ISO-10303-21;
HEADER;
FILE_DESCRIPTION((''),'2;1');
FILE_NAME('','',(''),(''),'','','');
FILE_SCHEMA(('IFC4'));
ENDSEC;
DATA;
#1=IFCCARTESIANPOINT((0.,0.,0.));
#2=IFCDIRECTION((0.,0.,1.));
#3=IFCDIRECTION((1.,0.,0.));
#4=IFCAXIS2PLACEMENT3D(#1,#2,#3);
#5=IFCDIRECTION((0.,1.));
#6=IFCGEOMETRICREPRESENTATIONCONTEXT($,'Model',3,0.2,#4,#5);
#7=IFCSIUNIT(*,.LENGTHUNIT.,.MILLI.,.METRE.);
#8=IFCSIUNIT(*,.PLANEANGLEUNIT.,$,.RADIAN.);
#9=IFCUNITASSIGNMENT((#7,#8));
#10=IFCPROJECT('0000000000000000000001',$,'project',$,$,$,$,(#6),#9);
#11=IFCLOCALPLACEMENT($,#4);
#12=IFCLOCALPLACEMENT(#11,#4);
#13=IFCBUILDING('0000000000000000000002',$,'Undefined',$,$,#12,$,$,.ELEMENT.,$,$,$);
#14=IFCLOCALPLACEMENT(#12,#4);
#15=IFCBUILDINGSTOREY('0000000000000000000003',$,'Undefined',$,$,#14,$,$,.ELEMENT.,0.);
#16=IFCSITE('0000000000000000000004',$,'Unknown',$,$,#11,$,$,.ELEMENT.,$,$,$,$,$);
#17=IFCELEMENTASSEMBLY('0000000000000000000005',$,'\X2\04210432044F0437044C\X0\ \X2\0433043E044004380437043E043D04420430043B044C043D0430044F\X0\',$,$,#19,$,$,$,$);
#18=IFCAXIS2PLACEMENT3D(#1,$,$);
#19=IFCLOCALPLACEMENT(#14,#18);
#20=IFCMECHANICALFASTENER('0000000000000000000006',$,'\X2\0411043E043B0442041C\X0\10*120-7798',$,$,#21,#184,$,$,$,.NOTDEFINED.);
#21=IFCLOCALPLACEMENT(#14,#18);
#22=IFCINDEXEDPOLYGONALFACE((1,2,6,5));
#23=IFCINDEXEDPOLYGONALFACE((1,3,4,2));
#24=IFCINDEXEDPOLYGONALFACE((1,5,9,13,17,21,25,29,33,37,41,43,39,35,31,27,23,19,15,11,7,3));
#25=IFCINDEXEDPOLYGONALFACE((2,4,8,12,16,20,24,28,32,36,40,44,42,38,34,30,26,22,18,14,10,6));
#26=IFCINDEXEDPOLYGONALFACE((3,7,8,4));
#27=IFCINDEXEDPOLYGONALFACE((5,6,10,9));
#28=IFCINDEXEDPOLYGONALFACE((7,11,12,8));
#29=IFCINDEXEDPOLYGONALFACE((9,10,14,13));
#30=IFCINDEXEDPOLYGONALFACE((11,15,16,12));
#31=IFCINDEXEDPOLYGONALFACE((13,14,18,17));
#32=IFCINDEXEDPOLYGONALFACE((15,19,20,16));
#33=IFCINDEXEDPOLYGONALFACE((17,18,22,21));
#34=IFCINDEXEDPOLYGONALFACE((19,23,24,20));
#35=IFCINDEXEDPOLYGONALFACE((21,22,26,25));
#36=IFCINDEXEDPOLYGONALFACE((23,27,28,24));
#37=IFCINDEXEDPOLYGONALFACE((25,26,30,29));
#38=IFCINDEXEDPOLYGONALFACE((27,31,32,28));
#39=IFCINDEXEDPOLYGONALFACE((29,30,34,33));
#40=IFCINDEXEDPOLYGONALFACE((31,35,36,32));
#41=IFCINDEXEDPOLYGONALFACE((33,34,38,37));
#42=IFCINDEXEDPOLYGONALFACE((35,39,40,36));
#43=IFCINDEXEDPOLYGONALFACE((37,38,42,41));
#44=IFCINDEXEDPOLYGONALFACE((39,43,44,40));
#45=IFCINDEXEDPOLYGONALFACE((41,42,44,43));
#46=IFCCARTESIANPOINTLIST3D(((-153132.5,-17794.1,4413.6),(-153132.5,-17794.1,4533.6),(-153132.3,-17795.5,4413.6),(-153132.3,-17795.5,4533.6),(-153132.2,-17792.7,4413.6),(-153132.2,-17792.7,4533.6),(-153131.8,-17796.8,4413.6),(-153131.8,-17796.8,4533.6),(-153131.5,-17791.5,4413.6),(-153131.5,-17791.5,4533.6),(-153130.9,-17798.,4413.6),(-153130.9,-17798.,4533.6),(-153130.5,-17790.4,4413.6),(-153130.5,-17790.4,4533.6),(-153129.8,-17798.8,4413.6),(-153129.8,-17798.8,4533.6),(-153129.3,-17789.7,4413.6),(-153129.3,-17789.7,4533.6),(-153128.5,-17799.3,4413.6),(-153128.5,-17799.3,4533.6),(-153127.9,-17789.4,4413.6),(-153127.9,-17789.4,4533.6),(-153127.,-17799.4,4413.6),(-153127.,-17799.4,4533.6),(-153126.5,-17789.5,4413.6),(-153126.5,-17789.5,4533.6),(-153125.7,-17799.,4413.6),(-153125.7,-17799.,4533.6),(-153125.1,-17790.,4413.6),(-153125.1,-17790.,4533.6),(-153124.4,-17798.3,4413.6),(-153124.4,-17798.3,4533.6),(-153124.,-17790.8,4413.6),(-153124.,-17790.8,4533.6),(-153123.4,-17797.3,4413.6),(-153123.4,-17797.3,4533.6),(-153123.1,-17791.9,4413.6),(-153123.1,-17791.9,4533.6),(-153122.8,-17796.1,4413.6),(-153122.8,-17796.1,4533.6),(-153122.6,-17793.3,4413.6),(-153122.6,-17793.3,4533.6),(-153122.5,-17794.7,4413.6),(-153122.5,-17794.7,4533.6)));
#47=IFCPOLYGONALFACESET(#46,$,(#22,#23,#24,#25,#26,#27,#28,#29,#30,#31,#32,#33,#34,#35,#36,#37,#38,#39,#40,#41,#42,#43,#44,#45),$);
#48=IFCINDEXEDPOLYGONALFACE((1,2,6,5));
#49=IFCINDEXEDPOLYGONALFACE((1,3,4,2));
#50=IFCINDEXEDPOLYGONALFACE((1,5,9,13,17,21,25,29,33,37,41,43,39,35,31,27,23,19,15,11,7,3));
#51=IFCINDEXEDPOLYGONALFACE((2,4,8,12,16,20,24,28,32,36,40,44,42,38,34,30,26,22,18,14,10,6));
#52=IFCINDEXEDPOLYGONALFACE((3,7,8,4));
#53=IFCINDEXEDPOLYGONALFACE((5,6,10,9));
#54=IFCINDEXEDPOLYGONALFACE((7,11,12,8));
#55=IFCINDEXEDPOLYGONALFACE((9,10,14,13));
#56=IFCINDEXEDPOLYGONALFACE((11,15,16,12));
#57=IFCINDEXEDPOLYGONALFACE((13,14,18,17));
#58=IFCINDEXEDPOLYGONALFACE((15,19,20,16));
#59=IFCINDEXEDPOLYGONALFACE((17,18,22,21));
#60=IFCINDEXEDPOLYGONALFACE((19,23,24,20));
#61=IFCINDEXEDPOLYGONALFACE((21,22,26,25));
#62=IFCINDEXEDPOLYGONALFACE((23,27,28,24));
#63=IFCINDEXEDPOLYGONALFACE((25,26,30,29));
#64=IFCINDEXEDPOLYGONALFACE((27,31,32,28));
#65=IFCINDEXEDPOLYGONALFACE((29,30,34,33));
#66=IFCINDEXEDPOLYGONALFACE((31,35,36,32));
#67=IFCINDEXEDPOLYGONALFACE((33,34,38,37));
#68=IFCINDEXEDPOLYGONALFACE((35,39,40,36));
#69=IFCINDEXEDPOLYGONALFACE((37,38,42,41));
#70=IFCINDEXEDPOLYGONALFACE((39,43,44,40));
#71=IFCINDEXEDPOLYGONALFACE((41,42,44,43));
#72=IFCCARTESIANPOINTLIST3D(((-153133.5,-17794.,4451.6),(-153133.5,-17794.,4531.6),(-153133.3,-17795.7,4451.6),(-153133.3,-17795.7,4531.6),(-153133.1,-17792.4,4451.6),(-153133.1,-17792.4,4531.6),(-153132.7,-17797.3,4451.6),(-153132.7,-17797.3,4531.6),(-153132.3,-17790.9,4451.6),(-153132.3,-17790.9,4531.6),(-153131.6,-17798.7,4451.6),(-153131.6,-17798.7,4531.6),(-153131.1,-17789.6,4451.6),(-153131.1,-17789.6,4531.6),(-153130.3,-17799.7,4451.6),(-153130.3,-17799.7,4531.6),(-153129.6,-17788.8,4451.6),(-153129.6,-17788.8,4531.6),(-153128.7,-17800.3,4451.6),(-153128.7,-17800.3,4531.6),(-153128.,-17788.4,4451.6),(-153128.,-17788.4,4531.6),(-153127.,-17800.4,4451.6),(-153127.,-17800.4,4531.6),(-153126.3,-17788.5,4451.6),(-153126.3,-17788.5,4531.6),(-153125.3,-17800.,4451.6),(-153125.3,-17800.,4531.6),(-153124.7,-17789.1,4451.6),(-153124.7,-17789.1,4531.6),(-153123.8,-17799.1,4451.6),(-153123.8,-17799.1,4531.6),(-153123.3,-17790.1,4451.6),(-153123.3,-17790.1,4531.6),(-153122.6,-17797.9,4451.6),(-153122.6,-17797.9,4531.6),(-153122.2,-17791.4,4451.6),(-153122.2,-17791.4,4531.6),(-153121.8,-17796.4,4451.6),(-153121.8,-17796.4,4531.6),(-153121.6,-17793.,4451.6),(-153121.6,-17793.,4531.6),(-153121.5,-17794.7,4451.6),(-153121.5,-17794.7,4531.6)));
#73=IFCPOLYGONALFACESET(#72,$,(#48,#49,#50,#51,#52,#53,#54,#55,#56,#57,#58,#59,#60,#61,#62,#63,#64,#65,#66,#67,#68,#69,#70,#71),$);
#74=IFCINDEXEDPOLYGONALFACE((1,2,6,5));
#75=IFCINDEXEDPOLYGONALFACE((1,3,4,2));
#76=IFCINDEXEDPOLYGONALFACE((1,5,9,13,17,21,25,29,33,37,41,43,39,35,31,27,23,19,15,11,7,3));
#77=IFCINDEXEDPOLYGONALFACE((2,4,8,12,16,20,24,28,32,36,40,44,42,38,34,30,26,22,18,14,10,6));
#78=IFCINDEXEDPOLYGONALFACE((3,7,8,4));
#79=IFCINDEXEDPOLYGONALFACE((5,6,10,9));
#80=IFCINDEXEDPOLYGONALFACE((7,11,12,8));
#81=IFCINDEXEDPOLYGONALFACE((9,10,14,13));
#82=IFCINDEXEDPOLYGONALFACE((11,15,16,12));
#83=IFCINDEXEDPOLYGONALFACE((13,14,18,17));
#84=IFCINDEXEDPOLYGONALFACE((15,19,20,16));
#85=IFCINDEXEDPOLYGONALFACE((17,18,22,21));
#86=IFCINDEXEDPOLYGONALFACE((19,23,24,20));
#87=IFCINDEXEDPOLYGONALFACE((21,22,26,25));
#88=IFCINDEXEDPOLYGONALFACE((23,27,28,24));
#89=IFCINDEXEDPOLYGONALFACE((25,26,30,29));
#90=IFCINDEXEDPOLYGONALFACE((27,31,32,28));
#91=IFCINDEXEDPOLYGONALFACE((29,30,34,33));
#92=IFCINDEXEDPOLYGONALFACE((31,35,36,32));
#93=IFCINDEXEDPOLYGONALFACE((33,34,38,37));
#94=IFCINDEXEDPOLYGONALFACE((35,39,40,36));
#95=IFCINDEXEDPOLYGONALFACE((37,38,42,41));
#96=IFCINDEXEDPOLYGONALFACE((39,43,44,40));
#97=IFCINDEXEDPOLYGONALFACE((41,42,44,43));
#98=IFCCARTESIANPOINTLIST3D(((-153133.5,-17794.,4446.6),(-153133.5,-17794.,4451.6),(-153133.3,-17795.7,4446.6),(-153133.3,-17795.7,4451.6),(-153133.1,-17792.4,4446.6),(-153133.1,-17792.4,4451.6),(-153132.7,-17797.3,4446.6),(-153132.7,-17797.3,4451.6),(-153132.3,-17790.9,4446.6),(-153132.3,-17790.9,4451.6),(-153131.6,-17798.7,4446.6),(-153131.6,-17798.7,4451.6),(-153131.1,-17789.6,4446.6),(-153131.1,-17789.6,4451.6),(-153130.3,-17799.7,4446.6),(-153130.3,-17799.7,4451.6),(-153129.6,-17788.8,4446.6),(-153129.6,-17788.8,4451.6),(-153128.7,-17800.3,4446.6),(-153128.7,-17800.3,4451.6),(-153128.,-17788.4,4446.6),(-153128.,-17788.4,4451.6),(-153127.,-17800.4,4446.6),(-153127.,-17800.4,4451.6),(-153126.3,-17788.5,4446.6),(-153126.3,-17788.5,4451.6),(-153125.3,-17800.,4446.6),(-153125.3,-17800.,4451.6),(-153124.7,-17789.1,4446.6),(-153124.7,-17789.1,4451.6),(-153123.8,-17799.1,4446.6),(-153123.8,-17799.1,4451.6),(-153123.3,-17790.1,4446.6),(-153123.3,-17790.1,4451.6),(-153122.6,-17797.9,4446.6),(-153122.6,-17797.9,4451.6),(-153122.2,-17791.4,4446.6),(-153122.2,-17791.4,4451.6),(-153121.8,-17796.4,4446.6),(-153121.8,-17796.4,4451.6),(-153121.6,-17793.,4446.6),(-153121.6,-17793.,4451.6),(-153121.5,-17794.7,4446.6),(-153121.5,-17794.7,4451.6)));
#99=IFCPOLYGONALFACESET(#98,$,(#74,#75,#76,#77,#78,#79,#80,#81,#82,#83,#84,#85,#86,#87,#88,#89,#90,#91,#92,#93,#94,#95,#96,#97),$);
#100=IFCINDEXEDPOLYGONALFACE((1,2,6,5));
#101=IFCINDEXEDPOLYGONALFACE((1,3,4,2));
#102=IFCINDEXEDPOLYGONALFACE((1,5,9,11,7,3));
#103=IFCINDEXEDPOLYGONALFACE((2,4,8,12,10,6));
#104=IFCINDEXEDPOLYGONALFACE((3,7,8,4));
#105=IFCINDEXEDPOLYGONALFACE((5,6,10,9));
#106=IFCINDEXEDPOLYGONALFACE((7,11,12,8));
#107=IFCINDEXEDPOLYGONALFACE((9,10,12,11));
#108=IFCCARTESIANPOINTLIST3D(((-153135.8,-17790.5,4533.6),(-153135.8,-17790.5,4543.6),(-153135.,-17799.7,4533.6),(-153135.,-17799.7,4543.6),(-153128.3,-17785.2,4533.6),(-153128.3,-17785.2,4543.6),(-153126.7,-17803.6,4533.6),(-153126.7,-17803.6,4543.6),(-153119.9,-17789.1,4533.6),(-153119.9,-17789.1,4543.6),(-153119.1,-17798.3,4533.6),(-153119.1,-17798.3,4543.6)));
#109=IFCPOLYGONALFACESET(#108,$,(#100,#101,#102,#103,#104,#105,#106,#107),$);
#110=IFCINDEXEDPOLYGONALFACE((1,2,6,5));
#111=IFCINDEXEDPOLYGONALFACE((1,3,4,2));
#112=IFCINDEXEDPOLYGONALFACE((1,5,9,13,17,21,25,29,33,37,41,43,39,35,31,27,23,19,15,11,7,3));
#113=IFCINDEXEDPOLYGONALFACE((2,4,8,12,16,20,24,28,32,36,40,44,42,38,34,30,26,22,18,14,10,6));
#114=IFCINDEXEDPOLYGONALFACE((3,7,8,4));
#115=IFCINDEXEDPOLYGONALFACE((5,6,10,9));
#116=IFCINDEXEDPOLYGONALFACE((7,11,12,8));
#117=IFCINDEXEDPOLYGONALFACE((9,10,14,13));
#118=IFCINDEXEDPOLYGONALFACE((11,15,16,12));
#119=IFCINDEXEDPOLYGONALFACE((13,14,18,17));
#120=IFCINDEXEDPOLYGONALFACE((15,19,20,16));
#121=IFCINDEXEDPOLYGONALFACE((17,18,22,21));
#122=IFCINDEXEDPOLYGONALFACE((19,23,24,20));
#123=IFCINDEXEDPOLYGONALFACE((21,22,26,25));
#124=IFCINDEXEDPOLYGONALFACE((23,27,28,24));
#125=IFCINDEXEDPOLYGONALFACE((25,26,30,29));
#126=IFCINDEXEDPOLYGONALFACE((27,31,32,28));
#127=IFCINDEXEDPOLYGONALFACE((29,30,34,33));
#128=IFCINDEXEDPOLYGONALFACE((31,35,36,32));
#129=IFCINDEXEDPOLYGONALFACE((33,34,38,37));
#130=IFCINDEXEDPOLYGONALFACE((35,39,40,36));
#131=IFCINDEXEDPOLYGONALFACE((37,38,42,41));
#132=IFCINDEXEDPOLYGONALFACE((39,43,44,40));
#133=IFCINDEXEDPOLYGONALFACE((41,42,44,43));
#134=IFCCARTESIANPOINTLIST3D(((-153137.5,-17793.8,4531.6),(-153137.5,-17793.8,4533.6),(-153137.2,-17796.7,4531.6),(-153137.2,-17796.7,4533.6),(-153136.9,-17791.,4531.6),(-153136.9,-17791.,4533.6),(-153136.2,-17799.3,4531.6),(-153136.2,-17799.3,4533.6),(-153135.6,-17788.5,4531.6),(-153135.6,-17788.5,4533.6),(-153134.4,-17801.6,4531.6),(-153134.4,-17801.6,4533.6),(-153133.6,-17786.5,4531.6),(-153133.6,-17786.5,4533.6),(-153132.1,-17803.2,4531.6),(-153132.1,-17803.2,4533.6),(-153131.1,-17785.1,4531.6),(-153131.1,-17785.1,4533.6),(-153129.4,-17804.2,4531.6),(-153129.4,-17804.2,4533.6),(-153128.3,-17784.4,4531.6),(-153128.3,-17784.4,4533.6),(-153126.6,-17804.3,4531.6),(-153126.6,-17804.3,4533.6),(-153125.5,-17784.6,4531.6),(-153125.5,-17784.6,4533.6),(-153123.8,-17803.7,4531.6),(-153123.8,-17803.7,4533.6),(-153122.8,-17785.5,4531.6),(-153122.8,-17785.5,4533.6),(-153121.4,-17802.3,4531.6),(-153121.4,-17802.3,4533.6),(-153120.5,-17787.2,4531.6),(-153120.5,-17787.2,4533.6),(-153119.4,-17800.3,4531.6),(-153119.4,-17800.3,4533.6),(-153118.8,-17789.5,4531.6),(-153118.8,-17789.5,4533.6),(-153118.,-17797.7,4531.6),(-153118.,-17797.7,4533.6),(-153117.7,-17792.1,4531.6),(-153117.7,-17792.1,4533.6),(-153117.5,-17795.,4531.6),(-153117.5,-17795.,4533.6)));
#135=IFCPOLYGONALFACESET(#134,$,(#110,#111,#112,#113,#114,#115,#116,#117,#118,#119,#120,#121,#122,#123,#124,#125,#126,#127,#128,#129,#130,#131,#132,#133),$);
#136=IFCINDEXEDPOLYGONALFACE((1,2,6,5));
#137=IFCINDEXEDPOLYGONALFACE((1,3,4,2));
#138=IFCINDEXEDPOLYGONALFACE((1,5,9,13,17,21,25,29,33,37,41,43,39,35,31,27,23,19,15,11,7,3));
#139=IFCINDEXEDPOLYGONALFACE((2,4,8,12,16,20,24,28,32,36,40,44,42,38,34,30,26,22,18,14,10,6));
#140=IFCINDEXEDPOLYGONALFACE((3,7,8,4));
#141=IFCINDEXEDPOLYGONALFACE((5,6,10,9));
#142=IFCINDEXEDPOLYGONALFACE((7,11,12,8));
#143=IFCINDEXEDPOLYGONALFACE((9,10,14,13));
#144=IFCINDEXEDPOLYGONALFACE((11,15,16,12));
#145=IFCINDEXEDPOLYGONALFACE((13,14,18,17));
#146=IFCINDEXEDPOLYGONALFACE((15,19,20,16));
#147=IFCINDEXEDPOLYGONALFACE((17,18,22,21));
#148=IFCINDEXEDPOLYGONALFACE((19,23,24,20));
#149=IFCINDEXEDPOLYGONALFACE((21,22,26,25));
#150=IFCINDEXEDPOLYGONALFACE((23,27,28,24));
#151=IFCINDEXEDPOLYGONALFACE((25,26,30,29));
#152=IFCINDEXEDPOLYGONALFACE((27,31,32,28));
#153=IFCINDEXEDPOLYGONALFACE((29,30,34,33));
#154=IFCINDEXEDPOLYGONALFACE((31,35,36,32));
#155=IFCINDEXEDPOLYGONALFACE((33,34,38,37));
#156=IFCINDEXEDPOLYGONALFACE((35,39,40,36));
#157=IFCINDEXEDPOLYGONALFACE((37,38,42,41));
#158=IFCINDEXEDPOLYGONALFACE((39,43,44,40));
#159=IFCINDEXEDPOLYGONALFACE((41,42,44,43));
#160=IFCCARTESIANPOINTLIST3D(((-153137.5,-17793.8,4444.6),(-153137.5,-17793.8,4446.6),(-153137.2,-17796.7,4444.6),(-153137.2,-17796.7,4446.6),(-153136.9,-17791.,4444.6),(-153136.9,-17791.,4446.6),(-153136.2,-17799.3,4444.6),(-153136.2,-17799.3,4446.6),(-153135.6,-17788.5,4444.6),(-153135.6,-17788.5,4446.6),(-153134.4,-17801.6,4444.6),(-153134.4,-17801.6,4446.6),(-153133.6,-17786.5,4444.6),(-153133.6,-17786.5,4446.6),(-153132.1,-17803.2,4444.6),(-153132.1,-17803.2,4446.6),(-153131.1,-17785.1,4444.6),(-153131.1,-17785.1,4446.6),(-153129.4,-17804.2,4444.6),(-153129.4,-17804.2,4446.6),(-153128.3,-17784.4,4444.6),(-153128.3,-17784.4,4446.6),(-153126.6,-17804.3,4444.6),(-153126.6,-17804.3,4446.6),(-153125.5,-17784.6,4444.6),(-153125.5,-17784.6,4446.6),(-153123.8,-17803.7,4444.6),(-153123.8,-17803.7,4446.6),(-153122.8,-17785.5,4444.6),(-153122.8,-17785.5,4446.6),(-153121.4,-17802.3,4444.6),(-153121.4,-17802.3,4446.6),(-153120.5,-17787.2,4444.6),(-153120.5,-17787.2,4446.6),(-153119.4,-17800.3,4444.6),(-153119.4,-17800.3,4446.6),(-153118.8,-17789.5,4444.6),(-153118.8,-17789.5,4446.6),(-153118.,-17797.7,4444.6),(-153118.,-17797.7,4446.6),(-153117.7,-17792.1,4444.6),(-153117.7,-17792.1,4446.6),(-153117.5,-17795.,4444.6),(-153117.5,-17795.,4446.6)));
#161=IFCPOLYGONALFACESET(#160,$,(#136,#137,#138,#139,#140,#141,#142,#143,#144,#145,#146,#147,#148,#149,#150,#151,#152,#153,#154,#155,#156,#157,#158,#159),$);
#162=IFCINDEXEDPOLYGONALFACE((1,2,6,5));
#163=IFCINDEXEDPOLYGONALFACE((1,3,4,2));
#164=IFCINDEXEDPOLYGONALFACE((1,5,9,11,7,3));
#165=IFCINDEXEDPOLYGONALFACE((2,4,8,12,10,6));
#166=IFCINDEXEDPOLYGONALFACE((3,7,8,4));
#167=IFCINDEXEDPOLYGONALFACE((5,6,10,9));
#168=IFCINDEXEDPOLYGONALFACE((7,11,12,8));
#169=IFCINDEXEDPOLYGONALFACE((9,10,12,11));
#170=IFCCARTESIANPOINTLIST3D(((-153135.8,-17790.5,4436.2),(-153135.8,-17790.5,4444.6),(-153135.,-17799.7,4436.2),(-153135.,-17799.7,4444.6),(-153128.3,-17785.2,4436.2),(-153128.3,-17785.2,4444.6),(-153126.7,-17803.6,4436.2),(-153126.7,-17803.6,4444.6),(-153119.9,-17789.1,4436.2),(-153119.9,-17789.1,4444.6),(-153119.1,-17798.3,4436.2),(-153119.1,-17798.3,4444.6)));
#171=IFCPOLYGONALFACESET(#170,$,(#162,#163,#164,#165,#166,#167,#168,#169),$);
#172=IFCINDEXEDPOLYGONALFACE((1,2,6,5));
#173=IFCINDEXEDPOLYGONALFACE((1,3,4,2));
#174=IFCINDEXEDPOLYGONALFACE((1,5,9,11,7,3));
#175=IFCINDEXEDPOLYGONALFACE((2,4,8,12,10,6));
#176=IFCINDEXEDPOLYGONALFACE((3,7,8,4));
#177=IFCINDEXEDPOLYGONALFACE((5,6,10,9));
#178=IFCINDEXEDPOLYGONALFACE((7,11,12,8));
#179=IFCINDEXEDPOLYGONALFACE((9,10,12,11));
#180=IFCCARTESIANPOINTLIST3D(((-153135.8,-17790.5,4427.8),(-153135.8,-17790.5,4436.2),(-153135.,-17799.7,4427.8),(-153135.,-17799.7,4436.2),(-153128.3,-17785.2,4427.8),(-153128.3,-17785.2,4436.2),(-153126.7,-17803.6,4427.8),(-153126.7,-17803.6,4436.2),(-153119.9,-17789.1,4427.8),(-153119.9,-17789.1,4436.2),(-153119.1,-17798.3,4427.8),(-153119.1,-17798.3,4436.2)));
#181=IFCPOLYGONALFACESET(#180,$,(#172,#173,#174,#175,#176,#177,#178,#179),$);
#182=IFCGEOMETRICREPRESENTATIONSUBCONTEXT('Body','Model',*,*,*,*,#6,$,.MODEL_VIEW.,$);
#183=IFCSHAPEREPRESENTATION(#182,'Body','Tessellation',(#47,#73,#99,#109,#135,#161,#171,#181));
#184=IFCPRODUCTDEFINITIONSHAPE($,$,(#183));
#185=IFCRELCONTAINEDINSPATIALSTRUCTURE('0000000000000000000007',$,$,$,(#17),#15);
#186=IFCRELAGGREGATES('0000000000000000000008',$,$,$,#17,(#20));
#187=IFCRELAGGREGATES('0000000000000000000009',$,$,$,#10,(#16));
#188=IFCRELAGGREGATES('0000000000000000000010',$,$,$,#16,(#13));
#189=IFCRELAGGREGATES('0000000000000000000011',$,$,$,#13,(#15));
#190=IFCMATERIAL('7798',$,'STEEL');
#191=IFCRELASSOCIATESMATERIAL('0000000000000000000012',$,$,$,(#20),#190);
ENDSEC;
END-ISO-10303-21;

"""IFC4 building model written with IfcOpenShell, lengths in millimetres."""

from ifc_helpers import new_model, si_unit, direction, frame, origin_with_axes, place, context, subcontext, project, spatial, line, arc, indexed_curve, outline, extrude, source, transform, mapped, material, element, aggregate, save


model = new_model("IFC4")

# Units and contexts
model_context = context("Model", 3, precision=0.2, world=origin_with_axes(), true_north=direction((0.0, 1.0)))
body_context = subcontext(model_context, "Body", "Model", "MODEL_VIEW")
ifc_project = project(units=[si_unit("LENGTHUNIT", "METRE", prefix="MILLI"), si_unit("PLANEANGLEUNIT", "RADIAN")], contexts=[model_context])

# Site, building, storey
site_placement = place(None, origin_with_axes())
site = spatial("IfcSite", under=ifc_project, at=site_placement, Name="Unknown", CompositionType="ELEMENT")
building_placement = place(site_placement, origin_with_axes())
building = spatial("IfcBuilding", under=site, at=building_placement, Name="Undefined", CompositionType="ELEMENT")
storey_placement = place(building_placement, origin_with_axes())
storey = spatial("IfcBuildingStorey", under=building, at=storey_placement, Name="Undefined", CompositionType="ELEMENT", Elevation=0.0)

# Shared definitions
ifc_material_1 = material(Name="7798", Category="STEEL")

# Element assembly, mechanical fastener
assembly_1_placement = place(storey_placement, frame((-154160.6, -17883.7, 4491.6), z_axis=(0.086114, -0.996285, 0.0), x_axis=(0.996285, 0.086114, 0.0)))
assembly_1 = element("IfcElementAssembly", 1, at=assembly_1_placement, inside=storey, Name="Связь горизонтальная")
shared_shape_1 = source(origin_with_axes(), body_context, "Body", "SweptSolid", [
    extrude(outline(indexed_curve([(5.0, 0.0), (0.0, 5.0), (-5.0, 0.0), (0.0, -5.0)], segments=[arc(1, 2, 3), arc(3, 4, 1)])), frame((0.0, 0.0, 87.0), z_axis=(0.0, 0.0, -1.0), x_axis=(0.0, 1.0, 0.0)), (0.0, 0.0, 1.0), 120.0),
    extrude(outline(indexed_curve([(6.0, 0.0), (0.0, 6.0), (-6.0, 0.0), (0.0, -6.0)], segments=[arc(1, 2, 3), arc(3, 4, 1)])), frame((0.0, 0.0, 85.0), z_axis=(0.0, 0.0, -1.0), x_axis=(0.0, 1.0, 0.0)), (0.0, 0.0, 1.0), 80.0),
    extrude(outline(indexed_curve([(6.0, 0.0), (0.0, 6.0), (-6.0, 0.0), (0.0, -6.0)], segments=[arc(1, 2, 3), arc(3, 4, 1)])), frame((0.0, 0.0, 5.0), z_axis=(0.0, 0.0, -1.0), x_axis=(0.0, 1.0, 0.0)), (0.0, 0.0, 1.0), 5.0),
    extrude(outline(indexed_curve([(9.2, 0.0), (4.6, 8.0), (-4.6, 8.0), (-9.2, 0.0), (-4.6, -8.0), (4.6, -8.0)], segments=[line(1, 2, 3, 4, 5, 6, 1)])), frame((0.0, 0.0, 97.0), z_axis=(0.0, 0.0, -1.0), x_axis=(0.0, 1.0, 0.0)), (0.0, 0.0, 1.0), 10.0),
    extrude(outline(indexed_curve([(10.0, 0.0), (0.0, 10.0), (-10.0, 0.0), (0.0, -10.0)], segments=[arc(1, 2, 3), arc(3, 4, 1)])), frame((0.0, 0.0, 87.0), z_axis=(0.0, 0.0, -1.0), x_axis=(0.0, 1.0, 0.0)), (0.0, 0.0, 1.0), 2.0),
    extrude(outline(indexed_curve([(10.0, 0.0), (0.0, 10.0), (-10.0, 0.0), (0.0, -10.0)], segments=[arc(1, 2, 3), arc(3, 4, 1)])), frame((0.0, 0.0, 0.0), z_axis=(0.0, 0.0, -1.0), x_axis=(0.0, 1.0, 0.0)), (0.0, 0.0, 1.0), 2.0),
    extrude(outline(indexed_curve([(9.2, 0.0), (4.6, 8.0), (-4.6, 8.0), (-9.2, 0.0), (-4.6, -8.0), (4.6, -8.0)], segments=[line(1, 2, 3, 4, 5, 6, 1)])), frame((0.0, 0.0, -2.0), z_axis=(0.0, 0.0, -1.0), x_axis=(0.0, 1.0, 0.0)), (0.0, 0.0, 1.0), 8.4),
    extrude(outline(indexed_curve([(9.2, 0.0), (4.6, 8.0), (-4.6, 8.0), (-9.2, 0.0), (-4.6, -8.0), (4.6, -8.0)], segments=[line(1, 2, 3, 4, 5, 6, 1)])), frame((0.0, 0.0, -10.4), z_axis=(0.0, 0.0, -1.0), x_axis=(0.0, 1.0, 0.0)), (0.0, 0.0, 1.0), 8.4),
])
mechanical_fastener_1_placement = place(assembly_1_placement, frame((1037.0, -45.0, 0.0), z_axis=(0.0, 1.0, 0.0), x_axis=(1.0, 0.0, 0.0)))
mechanical_fastener_1 = element("IfcMechanicalFastener", 2, at=mechanical_fastener_1_placement, material=ifc_material_1, Name="БолтМ10*120-7798", PredefinedType="NOTDEFINED", context=body_context, shape_type="MappedRepresentation", body=[
    mapped(shared_shape_1, transform((0.0, 0.0, 0.0))),
])
aggregate(assembly_1, [mechanical_fastener_1])

save(model, "model.ifc")
